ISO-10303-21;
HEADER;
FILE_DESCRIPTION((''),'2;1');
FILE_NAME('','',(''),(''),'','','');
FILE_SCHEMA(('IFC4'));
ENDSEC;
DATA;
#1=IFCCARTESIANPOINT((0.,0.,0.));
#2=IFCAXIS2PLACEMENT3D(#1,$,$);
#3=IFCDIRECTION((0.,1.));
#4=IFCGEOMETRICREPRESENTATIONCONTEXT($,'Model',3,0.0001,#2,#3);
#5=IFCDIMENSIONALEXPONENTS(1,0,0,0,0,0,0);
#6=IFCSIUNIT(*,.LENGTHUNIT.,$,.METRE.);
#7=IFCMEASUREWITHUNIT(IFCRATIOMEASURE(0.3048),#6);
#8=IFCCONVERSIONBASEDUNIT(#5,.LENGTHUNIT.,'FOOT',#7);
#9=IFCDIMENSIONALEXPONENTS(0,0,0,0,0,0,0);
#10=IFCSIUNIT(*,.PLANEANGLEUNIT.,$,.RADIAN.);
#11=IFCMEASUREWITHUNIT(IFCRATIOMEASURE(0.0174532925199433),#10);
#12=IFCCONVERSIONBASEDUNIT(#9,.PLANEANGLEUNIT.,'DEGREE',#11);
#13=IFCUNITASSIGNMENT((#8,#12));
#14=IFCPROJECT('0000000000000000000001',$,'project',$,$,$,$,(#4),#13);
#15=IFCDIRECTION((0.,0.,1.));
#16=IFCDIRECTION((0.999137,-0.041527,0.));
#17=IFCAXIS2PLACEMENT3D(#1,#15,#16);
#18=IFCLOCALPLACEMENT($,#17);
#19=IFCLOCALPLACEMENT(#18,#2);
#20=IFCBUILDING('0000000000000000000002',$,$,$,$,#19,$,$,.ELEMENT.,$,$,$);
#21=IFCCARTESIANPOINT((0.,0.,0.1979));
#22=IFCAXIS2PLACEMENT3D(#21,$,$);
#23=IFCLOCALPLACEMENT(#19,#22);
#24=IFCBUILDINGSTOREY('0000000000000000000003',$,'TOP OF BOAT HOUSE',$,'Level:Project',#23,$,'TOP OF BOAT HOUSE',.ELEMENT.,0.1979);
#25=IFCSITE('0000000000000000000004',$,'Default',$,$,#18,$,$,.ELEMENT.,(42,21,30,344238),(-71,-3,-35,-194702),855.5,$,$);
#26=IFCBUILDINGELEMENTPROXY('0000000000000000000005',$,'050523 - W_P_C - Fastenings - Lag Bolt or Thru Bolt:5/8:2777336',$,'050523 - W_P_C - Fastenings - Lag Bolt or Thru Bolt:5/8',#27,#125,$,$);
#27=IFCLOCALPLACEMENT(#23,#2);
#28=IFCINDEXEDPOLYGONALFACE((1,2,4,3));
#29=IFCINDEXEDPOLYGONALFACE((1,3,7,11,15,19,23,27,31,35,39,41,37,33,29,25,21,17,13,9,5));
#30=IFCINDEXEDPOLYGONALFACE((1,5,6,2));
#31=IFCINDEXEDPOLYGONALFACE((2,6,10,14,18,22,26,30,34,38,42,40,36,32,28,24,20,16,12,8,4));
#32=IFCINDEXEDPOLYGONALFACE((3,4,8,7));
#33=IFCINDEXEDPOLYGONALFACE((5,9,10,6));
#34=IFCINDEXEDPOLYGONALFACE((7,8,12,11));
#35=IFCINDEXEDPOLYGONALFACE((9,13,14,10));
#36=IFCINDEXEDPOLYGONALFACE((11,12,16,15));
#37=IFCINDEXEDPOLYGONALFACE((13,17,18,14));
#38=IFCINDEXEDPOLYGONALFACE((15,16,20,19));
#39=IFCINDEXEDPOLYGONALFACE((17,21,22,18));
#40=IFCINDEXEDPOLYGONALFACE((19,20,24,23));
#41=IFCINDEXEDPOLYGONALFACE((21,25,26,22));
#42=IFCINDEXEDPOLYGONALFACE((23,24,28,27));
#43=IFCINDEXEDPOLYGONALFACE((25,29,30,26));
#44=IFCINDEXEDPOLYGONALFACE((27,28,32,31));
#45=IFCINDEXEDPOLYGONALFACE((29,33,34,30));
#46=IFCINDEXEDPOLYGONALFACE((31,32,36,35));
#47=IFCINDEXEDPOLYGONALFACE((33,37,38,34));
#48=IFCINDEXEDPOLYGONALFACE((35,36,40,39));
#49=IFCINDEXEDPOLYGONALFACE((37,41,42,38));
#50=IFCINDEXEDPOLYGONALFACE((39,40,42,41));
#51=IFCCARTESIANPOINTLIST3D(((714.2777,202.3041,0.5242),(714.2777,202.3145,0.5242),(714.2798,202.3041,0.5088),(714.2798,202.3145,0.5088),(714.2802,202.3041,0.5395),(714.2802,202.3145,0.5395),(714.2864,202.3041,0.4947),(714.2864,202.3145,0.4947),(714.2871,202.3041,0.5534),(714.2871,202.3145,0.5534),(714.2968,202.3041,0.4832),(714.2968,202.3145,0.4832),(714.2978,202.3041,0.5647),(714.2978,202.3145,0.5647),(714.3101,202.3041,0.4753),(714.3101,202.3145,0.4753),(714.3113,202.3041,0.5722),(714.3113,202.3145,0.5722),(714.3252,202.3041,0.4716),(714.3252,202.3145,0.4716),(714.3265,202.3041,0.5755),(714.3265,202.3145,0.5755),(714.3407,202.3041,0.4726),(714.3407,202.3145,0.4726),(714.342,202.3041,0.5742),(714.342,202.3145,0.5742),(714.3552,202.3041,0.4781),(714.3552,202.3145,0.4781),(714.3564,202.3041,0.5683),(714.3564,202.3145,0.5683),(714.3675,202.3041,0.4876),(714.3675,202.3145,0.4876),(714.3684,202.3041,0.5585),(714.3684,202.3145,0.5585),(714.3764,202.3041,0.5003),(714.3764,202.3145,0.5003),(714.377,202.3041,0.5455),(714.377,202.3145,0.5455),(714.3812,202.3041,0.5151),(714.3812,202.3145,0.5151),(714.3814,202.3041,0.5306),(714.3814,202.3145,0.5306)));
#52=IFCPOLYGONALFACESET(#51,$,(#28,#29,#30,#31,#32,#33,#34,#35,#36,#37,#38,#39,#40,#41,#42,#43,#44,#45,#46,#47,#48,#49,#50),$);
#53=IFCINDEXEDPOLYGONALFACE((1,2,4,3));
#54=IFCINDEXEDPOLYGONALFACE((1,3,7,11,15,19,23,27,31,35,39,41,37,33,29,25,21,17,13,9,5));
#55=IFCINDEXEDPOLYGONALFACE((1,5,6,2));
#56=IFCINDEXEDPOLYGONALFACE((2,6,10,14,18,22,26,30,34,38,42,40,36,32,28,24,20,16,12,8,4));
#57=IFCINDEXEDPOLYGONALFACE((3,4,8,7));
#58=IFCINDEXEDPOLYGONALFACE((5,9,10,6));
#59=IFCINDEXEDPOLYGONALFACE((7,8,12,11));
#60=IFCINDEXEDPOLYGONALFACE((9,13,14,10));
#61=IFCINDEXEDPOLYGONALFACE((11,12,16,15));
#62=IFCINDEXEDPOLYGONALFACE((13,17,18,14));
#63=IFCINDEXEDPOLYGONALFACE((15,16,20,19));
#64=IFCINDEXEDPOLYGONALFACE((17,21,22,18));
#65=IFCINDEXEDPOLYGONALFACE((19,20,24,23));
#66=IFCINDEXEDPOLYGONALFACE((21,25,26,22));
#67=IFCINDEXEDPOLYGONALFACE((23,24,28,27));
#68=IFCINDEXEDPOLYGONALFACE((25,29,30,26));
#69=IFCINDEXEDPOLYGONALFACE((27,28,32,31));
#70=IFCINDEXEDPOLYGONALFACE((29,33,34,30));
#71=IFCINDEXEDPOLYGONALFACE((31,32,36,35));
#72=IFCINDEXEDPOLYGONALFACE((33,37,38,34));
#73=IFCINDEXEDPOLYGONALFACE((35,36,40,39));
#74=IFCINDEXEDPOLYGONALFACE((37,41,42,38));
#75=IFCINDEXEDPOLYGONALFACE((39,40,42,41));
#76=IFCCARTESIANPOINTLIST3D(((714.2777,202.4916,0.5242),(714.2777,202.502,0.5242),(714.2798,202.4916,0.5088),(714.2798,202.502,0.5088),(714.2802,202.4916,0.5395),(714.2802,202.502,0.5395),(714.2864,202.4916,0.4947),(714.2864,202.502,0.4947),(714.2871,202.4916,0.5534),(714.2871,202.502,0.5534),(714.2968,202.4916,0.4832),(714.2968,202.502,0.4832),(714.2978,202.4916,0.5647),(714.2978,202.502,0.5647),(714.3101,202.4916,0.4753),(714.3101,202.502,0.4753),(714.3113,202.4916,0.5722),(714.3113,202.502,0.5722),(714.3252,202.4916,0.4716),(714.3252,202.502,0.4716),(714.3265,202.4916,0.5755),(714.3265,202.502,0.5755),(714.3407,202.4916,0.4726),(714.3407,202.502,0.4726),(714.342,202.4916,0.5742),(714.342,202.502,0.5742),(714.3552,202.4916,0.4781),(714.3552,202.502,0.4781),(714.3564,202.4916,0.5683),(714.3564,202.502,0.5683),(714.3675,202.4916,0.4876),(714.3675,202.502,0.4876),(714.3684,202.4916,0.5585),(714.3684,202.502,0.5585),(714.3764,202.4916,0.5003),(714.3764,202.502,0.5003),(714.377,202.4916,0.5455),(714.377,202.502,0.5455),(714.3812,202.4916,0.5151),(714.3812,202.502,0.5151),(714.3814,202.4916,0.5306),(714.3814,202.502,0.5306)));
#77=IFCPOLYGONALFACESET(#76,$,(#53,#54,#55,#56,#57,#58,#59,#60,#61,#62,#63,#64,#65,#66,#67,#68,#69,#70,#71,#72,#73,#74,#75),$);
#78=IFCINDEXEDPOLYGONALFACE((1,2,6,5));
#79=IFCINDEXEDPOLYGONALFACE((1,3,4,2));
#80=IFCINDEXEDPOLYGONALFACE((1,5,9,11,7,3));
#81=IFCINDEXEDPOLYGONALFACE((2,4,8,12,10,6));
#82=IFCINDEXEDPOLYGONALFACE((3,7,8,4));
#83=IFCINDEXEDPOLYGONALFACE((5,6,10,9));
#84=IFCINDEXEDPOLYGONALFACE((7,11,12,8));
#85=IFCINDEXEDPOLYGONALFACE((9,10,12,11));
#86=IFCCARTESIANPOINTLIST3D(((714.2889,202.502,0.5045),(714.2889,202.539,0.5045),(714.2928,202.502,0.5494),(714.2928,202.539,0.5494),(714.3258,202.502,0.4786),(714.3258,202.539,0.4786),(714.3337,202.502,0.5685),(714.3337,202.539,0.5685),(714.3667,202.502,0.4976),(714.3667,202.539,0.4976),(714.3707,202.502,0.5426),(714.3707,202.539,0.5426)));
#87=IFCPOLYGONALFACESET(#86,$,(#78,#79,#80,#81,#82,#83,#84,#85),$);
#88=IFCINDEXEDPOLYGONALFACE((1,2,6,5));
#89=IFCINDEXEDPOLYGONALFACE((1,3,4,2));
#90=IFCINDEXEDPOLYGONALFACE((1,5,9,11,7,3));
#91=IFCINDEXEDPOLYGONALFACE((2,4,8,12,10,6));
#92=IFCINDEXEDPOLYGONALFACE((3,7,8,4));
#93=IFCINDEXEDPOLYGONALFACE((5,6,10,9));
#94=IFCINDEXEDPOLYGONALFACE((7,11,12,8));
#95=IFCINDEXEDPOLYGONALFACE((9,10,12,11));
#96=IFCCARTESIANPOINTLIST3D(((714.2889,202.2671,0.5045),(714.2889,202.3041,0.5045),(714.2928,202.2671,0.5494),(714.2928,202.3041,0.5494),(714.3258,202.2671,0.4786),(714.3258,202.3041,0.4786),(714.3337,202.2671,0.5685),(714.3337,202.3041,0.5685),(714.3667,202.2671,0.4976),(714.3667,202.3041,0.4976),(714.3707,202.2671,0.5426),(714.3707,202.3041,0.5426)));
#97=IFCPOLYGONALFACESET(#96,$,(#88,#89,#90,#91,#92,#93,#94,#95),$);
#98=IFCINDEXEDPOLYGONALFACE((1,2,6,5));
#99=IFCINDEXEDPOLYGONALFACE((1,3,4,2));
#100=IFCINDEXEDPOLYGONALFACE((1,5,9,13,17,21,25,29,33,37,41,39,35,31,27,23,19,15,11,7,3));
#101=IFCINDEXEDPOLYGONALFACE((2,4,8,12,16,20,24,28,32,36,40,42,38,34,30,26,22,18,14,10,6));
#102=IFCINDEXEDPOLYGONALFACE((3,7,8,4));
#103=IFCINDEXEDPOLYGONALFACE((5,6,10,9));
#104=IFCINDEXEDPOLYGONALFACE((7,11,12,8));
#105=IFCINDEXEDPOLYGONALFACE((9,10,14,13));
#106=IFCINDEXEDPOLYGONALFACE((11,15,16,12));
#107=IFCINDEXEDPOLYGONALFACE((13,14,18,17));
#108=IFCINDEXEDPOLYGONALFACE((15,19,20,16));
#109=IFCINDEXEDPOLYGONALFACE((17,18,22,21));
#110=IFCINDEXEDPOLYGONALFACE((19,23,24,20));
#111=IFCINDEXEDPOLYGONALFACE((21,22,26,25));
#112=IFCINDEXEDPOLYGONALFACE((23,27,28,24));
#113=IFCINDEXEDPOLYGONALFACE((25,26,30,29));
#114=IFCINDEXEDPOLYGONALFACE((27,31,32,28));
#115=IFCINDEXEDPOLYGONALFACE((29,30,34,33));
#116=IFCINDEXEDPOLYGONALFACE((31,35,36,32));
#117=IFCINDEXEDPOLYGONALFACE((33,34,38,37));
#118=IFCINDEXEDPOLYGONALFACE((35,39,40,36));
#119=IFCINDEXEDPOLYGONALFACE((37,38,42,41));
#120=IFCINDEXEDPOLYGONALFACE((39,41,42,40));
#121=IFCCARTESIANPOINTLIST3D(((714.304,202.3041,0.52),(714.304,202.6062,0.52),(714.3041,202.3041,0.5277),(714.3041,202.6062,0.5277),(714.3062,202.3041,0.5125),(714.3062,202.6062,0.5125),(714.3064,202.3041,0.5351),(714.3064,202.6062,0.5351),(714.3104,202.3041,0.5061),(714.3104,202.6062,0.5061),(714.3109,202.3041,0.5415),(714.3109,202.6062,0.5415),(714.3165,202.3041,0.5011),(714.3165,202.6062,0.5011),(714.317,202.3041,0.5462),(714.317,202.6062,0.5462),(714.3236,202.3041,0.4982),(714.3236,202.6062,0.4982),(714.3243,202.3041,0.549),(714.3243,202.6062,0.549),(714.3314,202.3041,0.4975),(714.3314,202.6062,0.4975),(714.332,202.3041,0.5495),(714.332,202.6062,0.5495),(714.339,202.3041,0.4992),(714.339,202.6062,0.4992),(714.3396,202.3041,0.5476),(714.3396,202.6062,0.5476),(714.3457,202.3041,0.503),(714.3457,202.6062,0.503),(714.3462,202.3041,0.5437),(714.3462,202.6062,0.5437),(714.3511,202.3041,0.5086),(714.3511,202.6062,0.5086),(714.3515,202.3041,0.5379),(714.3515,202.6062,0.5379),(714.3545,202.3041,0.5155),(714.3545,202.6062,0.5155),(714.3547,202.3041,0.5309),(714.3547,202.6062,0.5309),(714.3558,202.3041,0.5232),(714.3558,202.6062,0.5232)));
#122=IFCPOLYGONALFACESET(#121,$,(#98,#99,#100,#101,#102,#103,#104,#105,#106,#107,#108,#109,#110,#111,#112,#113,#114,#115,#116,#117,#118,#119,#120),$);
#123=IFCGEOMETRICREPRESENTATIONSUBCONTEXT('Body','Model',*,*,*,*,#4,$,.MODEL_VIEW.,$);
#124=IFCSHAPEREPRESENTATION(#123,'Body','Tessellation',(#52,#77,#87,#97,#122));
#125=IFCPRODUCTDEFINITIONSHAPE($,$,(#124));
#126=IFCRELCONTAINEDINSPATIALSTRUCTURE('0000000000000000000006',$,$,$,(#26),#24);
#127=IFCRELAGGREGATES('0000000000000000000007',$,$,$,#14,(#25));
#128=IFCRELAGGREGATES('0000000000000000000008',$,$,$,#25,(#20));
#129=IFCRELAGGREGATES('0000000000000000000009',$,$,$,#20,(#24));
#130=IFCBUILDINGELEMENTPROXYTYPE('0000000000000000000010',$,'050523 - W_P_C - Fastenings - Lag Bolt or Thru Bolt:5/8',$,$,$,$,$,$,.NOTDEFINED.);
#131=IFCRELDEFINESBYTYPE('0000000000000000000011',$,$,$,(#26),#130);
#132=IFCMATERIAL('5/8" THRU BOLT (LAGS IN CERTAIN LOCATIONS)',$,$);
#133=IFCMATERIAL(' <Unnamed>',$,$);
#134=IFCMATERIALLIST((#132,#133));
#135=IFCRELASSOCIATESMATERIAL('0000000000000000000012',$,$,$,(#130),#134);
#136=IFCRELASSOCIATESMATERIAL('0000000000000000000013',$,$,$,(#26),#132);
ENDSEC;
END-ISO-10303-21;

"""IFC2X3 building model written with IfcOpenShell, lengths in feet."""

from ifc_helpers import new_model, entity, si_unit, converted_unit, direction, frame, frame_2d, origin, place, context, subcontext, project, spatial, polyline, circle, outline, extrude, source, transform, mapped, material, material_list, type_object, type_shapes, element, save


model = new_model("IFC2X3")

# Units and contexts
model_context = context("Model", 3, precision=0.0001, world=origin(), true_north=direction((0.0, 1.0)))
body_context = subcontext(model_context, "Body", "Model", "MODEL_VIEW")
ifc_project = project(units=[converted_unit("LENGTHUNIT", "FOOT", entity("IfcRatioMeasure", 0.3048), si_unit("LENGTHUNIT", "METRE"), dimensions=[1, 0, 0, 0, 0, 0, 0]), converted_unit("PLANEANGLEUNIT", "DEGREE", entity("IfcRatioMeasure", 0.0174532925199433), si_unit("PLANEANGLEUNIT", "RADIAN"), dimensions=[0, 0, 0, 0, 0, 0, 0])], contexts=[model_context])

# Site, building, storey
site_placement = place(None, frame((0.0, 0.0, 0.0), z_axis=(0.0, 0.0, 1.0), x_axis=(0.999137, -0.041527, 0.0)))
site = spatial("IfcSite", under=ifc_project, at=site_placement, Name="Default", CompositionType="ELEMENT", RefLatitude=(42, 21, 30, 344238), RefLongitude=(-71, -3, -35, -194702), RefElevation=855.5)
building_placement = place(site_placement, origin())
building = spatial("IfcBuilding", under=site, at=building_placement, CompositionType="ELEMENT")
storey_placement = place(building_placement, frame((0.0, 0.0, 0.1979)))
storey = spatial("IfcBuildingStorey", under=building, at=storey_placement, Name="TOP OF BOAT HOUSE", ObjectType="Level:Project", LongName="TOP OF BOAT HOUSE", CompositionType="ELEMENT", Elevation=0.1979)

# Building element proxy
ifc_material_1 = material(Name="5/8\" THRU BOLT (LAGS IN CERTAIN LOCATIONS)")
ifc_material_2 = material(Name=" <Unnamed>")
ifc_material_list_1 = material_list([ifc_material_1, ifc_material_2])
building_element_proxy_type_1 = type_object("IfcBuildingElementProxyType", Name="050523 - W_P_C - Fastenings - Lag Bolt or Thru Bolt:5/8", PredefinedType="NOTDEFINED", material=ifc_material_list_1)
shared_shape_1 = source(origin(), body_context, "Body", "SweptSolid", [
    extrude(circle(Radius=0.0521, at=frame_2d((0.0, 0.0), x_axis=(1.0, 0.0))), frame((0.0, 0.0, 0.0), z_axis=(0.0, 0.0, 1.0), x_axis=(0.0, -1.0, 0.0)), (0.0, 0.0, 1.0), 0.0104),
    extrude(circle(Radius=0.0521, at=frame_2d((0.0, 0.0), x_axis=(1.0, 0.0))), frame((0.0, 0.0, -0.1875), z_axis=(0.0, 0.0, 1.0), x_axis=(0.0, -1.0, 0.0)), (0.0, 0.0, 1.0), 0.0104),
    extrude(outline(polyline([(-0.0226, -0.0391), (0.0226, -0.0391), (0.0451, 0.0), (0.0226, 0.0391), (-0.0226, 0.0391), (-0.0451, 0.0), (-0.0226, -0.0391)])), frame((0.0, 0.0, -0.2245), z_axis=(0.0, 0.0, 1.0), x_axis=(0.866025, -0.5, 0.0)), (0.0, 0.0, 1.0), 0.037),
    extrude(outline(polyline([(-0.0226, -0.0391), (0.0226, -0.0391), (0.0451, 0.0), (0.0226, 0.0391), (-0.0226, 0.0391), (-0.0451, 0.0), (-0.0226, -0.0391)])), frame((0.0, 0.0, 0.0104), z_axis=(0.0, 0.0, 1.0), x_axis=(0.0, -1.0, 0.0)), (0.0, 0.0, 1.0), 0.037),
    extrude(circle(Radius=0.026, at=frame_2d((0.0, 0.0), x_axis=(1.0, 0.0))), frame((0.0, 0.0, -0.2917), z_axis=(0.0, 0.0, 1.0), x_axis=(0.0, 1.0, 0.0)), (0.0, 0.0, 1.0), 0.3021),
])
type_shapes(building_element_proxy_type_1, [shared_shape_1])
for number, where, z_axis, x_axis, name in (
    (1, (714.3298, 202.3145, 0.5235), (0.0, -1.0, 0.0), (0.996195, 0.0, -0.087156), "050523 - W_P_C - Fastenings - Lag Bolt or Thru Bolt:5/8:2777336"),
):
    element("IfcBuildingElementProxy", number, at=place(storey_placement, frame(where, z_axis=z_axis, x_axis=x_axis)), inside=storey, type_object=building_element_proxy_type_1, material=ifc_material_1, Name=name, ObjectType="050523 - W_P_C - Fastenings - Lag Bolt or Thru Bolt:5/8", context=body_context, shape_type="MappedRepresentation", body=[
        mapped(shared_shape_1, transform((0.0, 0.0, 0.0), scale=1.0)),
    ])

save(model, "model.ifc")
